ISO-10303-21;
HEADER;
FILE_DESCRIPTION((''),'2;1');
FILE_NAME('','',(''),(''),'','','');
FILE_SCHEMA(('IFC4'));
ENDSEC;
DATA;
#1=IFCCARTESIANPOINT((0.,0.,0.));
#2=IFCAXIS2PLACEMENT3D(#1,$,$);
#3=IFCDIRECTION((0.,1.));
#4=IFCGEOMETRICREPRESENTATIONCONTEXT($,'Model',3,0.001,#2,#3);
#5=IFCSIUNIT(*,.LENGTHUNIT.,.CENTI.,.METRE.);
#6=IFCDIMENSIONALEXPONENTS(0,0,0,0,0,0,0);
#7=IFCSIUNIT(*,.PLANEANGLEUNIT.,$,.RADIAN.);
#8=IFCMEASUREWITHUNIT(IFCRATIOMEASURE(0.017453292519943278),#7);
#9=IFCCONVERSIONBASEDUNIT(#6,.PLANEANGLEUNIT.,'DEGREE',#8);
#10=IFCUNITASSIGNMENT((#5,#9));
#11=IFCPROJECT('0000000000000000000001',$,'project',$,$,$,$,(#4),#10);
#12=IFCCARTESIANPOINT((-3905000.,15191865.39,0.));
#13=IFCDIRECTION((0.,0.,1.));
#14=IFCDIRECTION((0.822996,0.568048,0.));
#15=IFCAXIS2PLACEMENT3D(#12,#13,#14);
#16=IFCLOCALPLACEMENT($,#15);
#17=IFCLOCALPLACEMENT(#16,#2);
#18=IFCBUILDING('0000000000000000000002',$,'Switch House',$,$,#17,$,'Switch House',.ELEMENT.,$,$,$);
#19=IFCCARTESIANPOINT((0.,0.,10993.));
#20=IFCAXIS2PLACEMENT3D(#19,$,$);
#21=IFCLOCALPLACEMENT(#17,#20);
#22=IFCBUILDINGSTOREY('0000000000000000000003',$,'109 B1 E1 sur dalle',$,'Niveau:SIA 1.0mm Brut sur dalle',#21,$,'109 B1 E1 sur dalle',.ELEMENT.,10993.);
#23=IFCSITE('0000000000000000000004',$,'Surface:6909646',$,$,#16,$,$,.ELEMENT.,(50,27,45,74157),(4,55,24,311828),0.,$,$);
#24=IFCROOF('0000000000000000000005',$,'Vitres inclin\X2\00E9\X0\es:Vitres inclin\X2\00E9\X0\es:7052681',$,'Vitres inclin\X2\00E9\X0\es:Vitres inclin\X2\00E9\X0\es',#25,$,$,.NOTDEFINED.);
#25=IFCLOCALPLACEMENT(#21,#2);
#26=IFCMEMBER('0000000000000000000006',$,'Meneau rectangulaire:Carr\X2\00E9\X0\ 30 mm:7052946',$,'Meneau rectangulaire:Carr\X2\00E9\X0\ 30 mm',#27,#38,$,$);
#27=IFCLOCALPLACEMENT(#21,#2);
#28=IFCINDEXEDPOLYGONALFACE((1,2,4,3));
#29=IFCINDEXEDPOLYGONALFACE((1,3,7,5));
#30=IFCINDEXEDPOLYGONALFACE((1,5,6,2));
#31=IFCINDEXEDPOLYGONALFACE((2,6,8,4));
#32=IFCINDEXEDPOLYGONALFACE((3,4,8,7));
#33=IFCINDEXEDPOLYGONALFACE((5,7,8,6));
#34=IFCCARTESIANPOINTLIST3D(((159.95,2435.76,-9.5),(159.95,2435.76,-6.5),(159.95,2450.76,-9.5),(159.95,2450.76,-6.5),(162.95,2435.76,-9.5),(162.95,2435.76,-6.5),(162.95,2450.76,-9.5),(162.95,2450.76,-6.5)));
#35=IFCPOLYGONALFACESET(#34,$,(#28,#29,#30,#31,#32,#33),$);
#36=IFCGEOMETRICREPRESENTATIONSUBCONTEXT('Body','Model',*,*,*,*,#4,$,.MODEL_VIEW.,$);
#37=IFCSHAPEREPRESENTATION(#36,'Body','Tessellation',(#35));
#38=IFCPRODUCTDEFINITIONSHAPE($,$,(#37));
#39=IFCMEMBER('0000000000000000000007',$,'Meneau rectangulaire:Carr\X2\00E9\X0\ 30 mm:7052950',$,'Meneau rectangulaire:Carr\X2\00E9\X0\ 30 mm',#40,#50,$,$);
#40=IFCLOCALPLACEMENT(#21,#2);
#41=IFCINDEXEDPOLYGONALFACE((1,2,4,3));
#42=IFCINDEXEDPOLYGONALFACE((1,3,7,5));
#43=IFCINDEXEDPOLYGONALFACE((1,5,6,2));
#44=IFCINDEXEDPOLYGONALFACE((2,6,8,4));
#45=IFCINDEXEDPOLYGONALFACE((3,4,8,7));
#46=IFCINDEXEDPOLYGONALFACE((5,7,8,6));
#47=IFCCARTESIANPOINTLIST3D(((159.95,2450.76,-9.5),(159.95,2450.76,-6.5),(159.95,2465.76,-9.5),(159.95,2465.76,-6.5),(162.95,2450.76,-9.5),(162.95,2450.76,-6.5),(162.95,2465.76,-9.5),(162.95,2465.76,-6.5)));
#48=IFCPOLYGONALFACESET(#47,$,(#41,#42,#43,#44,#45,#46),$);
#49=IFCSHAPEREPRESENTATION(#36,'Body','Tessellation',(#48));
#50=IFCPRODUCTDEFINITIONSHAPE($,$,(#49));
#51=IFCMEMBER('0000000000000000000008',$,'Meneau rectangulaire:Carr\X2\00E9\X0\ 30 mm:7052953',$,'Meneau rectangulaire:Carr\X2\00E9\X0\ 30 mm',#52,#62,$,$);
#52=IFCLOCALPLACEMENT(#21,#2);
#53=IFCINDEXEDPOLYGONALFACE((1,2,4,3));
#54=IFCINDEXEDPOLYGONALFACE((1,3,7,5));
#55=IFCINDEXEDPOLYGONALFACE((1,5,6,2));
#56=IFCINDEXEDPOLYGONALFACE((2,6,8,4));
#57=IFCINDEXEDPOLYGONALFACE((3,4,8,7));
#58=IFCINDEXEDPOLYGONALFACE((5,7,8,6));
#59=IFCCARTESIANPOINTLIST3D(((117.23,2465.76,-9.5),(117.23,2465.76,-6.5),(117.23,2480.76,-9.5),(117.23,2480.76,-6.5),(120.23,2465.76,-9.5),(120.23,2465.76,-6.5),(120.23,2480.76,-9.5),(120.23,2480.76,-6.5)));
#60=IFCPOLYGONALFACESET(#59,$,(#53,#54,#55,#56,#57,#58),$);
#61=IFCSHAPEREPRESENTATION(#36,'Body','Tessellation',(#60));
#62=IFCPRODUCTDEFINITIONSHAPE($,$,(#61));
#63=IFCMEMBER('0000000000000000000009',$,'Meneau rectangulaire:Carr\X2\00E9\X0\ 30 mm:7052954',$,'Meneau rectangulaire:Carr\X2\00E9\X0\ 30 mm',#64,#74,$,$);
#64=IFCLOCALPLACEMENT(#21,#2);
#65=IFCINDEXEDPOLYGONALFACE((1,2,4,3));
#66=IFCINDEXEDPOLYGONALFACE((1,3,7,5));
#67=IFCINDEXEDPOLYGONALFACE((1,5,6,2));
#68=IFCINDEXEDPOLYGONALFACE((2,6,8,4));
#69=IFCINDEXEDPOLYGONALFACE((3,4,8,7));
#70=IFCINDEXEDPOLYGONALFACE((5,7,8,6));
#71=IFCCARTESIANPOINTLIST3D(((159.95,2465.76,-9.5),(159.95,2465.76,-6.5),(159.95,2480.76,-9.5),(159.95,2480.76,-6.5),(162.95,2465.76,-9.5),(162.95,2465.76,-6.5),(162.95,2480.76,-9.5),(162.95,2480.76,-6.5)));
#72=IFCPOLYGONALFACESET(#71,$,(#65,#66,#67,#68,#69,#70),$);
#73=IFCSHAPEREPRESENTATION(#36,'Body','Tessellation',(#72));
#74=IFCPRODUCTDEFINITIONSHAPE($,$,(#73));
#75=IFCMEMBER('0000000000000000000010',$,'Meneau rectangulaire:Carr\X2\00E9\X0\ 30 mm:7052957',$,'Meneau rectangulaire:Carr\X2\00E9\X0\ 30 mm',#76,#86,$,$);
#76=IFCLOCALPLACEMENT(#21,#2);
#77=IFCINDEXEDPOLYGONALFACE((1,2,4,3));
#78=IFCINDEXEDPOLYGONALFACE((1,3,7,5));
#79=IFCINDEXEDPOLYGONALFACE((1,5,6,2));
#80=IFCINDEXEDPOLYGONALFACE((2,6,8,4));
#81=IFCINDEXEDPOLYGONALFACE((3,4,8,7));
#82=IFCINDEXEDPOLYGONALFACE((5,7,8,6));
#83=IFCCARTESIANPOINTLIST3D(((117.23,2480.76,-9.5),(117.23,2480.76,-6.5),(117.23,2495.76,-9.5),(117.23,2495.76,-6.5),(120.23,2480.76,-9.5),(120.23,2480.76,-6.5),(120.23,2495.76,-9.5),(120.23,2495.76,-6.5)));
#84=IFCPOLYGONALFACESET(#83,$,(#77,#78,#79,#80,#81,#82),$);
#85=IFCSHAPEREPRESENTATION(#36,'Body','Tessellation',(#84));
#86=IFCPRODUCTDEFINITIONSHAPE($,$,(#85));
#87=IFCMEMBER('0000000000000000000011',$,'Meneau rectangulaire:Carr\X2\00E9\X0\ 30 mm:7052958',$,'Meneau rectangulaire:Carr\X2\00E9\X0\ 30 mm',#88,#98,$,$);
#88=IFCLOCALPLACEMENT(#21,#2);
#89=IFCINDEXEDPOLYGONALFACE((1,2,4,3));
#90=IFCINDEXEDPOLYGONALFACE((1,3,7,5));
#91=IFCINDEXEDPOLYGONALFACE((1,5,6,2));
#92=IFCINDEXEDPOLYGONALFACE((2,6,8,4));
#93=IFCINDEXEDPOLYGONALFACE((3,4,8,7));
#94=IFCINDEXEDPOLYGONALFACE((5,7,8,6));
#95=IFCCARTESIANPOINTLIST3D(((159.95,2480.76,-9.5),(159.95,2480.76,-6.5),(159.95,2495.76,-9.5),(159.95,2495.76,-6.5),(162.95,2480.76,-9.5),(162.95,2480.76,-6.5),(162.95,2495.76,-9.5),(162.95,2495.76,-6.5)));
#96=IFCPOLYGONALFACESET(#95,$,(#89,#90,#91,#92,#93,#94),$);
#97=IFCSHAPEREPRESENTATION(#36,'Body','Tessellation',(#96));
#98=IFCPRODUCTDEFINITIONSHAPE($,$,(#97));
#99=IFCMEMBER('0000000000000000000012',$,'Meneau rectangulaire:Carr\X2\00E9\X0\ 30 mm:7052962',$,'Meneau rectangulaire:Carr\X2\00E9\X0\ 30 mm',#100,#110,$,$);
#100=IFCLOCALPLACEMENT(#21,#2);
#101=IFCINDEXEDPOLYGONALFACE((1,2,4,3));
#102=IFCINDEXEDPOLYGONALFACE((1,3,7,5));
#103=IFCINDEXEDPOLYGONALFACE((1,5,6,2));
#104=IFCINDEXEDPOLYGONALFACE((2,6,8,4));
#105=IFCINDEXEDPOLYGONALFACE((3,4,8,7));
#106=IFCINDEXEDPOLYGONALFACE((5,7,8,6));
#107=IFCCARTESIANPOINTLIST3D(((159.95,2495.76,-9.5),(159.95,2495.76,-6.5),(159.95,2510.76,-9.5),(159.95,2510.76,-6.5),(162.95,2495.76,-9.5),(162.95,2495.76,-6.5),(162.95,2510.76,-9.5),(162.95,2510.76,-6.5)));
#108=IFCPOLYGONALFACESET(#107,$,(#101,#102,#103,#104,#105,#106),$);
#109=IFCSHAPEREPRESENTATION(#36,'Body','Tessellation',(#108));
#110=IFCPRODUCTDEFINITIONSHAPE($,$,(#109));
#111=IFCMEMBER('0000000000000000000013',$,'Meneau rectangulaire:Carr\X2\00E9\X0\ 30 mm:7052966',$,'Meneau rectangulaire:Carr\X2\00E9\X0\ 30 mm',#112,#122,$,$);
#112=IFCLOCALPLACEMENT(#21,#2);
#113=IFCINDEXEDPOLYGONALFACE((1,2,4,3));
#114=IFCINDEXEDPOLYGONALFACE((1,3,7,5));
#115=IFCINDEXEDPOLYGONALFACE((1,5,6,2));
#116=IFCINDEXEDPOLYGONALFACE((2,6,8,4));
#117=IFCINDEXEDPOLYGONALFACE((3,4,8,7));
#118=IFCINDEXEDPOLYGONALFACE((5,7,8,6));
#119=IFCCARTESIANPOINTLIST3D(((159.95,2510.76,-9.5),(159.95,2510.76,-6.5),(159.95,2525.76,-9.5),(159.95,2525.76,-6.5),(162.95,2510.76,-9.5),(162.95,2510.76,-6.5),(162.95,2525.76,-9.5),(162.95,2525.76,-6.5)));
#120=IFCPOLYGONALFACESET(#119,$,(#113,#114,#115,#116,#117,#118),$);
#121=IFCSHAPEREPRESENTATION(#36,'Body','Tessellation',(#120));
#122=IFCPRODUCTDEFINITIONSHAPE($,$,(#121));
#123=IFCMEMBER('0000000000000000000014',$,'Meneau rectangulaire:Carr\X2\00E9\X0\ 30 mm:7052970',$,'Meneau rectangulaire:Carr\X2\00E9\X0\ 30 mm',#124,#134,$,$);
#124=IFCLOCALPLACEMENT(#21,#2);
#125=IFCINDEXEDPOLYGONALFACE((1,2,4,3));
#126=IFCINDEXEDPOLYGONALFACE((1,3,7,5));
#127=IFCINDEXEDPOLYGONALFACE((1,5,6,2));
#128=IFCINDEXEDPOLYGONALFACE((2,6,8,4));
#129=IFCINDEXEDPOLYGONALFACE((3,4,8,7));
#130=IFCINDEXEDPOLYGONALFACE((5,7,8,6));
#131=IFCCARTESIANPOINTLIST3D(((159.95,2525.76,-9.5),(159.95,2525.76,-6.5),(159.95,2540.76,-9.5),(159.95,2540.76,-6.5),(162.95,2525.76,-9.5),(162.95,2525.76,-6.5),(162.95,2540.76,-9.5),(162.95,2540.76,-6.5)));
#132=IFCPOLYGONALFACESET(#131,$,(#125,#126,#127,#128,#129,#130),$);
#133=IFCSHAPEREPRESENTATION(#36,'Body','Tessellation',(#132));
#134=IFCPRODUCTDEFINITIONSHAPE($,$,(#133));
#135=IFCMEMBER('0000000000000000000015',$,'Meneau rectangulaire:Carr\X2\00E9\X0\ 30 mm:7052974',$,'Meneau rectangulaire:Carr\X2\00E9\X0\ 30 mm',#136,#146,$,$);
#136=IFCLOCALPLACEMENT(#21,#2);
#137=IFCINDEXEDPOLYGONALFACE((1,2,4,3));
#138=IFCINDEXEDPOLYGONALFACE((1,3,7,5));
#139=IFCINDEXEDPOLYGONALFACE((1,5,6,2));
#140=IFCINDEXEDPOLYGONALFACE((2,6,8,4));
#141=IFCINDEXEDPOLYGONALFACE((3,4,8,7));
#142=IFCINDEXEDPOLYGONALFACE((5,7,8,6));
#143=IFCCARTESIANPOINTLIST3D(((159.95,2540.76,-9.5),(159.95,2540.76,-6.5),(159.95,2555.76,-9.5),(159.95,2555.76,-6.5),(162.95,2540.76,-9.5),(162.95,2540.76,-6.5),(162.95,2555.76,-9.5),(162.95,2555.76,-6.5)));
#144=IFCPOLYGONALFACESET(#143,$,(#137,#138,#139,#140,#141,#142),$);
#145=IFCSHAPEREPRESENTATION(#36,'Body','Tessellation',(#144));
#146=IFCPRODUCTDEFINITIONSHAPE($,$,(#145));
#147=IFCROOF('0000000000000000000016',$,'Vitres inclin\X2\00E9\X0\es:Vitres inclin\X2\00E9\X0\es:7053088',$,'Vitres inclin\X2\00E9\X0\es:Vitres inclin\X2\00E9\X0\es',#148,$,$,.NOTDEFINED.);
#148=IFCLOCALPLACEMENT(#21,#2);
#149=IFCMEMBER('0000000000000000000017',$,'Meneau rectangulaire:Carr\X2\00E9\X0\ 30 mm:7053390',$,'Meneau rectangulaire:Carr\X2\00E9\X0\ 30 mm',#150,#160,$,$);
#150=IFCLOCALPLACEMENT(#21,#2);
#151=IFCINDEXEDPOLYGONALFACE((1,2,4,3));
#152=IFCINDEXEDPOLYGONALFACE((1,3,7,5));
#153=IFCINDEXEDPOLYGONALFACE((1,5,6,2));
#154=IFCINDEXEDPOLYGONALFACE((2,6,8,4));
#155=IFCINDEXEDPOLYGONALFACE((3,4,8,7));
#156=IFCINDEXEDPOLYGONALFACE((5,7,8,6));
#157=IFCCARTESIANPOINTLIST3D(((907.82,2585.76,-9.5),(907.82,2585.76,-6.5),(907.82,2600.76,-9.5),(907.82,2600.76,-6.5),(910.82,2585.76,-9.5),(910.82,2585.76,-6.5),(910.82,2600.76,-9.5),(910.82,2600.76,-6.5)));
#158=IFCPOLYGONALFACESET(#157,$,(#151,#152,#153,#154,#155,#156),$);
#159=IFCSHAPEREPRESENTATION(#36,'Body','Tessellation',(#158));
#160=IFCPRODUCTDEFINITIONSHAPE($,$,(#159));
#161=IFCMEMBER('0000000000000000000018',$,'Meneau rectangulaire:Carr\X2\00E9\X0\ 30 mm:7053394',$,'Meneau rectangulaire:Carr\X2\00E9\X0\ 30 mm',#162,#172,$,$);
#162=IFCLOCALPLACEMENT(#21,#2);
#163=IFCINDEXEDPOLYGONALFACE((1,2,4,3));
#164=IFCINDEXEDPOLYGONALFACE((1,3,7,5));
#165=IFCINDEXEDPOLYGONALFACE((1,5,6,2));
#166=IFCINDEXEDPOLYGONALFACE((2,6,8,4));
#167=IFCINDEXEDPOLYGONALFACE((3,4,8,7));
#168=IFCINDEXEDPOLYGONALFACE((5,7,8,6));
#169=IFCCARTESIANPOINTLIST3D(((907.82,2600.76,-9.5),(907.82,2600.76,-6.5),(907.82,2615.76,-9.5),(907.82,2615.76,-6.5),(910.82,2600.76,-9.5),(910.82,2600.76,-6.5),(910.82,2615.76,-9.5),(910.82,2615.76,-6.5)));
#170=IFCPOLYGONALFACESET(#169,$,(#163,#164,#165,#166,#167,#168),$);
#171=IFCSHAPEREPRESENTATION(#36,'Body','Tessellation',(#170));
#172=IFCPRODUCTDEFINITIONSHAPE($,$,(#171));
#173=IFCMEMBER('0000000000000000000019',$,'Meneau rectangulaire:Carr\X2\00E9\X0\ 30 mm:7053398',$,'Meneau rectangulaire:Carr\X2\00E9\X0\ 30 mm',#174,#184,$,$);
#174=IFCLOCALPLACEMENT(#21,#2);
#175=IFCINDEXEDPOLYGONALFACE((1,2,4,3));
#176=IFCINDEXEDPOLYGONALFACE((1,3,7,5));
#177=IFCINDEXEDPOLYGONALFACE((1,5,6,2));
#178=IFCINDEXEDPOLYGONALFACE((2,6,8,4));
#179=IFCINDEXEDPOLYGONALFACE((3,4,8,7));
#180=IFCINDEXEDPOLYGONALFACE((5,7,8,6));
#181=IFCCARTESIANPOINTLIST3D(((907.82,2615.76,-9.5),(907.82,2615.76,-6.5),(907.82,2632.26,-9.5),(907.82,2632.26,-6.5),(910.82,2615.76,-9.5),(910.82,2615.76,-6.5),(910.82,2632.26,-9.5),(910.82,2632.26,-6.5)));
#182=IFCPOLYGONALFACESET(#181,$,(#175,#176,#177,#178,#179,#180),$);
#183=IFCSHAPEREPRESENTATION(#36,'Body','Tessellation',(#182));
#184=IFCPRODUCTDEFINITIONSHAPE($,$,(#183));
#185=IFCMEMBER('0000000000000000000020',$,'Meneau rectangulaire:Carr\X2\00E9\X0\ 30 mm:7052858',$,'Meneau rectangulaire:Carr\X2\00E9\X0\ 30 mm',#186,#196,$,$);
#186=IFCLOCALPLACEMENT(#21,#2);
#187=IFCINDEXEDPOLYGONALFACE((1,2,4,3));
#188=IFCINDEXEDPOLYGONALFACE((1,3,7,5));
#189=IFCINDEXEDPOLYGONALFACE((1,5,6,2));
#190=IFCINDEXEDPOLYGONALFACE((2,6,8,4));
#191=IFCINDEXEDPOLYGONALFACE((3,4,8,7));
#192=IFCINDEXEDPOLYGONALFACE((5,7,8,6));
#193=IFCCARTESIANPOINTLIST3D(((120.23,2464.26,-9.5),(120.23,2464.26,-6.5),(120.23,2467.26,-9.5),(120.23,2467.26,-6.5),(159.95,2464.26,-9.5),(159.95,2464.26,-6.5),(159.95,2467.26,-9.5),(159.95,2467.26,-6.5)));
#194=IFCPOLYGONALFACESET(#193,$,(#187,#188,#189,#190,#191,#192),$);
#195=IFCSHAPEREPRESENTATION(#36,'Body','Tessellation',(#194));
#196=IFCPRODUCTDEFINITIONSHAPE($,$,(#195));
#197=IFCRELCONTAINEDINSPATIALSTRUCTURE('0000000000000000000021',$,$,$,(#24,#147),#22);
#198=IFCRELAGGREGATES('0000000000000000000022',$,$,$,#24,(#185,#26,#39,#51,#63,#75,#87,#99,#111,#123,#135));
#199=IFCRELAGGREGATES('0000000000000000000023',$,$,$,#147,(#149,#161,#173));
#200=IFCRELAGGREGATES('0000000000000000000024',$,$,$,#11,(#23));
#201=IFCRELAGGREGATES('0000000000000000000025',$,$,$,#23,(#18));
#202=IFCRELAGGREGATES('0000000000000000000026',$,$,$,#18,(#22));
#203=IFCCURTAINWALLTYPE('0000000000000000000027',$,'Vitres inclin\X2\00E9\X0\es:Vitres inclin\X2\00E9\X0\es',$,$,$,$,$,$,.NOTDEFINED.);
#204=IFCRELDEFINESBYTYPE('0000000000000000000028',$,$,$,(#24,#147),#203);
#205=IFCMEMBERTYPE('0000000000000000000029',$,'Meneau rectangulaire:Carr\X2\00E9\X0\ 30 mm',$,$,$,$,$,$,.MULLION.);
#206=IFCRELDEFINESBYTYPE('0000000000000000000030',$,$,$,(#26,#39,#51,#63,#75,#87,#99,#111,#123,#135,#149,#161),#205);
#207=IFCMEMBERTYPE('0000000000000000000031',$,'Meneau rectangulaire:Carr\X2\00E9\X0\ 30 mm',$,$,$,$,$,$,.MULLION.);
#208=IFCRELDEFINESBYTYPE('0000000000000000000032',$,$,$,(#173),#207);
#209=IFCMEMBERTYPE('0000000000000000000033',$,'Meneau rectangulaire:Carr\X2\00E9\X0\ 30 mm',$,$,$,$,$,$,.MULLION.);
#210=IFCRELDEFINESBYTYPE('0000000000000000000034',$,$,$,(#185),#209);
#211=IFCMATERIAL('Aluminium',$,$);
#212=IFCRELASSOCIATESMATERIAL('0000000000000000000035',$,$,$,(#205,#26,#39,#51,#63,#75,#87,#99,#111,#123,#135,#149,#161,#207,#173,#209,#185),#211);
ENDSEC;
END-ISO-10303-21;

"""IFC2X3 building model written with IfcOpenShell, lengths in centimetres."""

from ifc_helpers import new_model, entity, si_unit, converted_unit, direction, frame, origin, origin_2d_with_axis, place, context, subcontext, project, spatial, rectangle, extrude, source, transform, mapped, material, type_object, type_shapes, element, aggregate, save


model = new_model("IFC2X3")

# Units and contexts
model_context = context("Model", 3, precision=0.001, world=origin(), true_north=direction((0.0, 1.0)))
body_context = subcontext(model_context, "Body", "Model", "MODEL_VIEW")
ifc_project = project(units=[si_unit("LENGTHUNIT", "METRE", prefix="CENTI"), converted_unit("PLANEANGLEUNIT", "DEGREE", entity("IfcRatioMeasure", 0.017453292519943278), si_unit("PLANEANGLEUNIT", "RADIAN"), dimensions=[0, 0, 0, 0, 0, 0, 0])], contexts=[model_context])

# Site, building, storey
site_placement = place(None, frame((-3905000.0, 15191865.39, 0.0), z_axis=(0.0, 0.0, 1.0), x_axis=(0.822996, 0.568048, 0.0)))
site = spatial("IfcSite", under=ifc_project, at=site_placement, Name="Surface:6909646", CompositionType="ELEMENT", RefLatitude=(50, 27, 45, 74157), RefLongitude=(4, 55, 24, 311828), RefElevation=0.0)
building_placement = place(site_placement, origin())
building = spatial("IfcBuilding", under=site, at=building_placement, Name="Switch House", LongName="Switch House", CompositionType="ELEMENT")
storey_placement = place(building_placement, frame((0.0, 0.0, 10993.0)))
storey = spatial("IfcBuildingStorey", under=building, at=storey_placement, Name="109 B1 E1 sur dalle", ObjectType="Niveau:SIA 1.0mm Brut sur dalle", LongName="109 B1 E1 sur dalle", CompositionType="ELEMENT", Elevation=10993.0)

# Roofs, members
curtain_wall_type = type_object("IfcCurtainWallType", Name="Vitres inclinées:Vitres inclinées", PredefinedType="NOTDEFINED")
roof_1_placement = place(storey_placement, frame((0.0, 0.0, -10993.0)))
roof_1 = element("IfcRoof", 1, at=roof_1_placement, inside=storey, type_object=curtain_wall_type, Name="Vitres inclinées:Vitres inclinées:7052681", ObjectType="Vitres inclinées:Vitres inclinées", ShapeType="NOTDEFINED")
ifc_material = material(Name="Aluminium")
member_type_1 = type_object("IfcMemberType", Name="Meneau rectangulaire:Carré 30 mm", PredefinedType="MULLION", material=ifc_material)
shared_shape_1 = source(origin(), body_context, "Body", "SweptSolid", [
    extrude(rectangle(XDim=3.0, YDim=3.0, at=origin_2d_with_axis()), frame((0.0, 0.0, -15.0), z_axis=(0.0, 0.0, 1.0), x_axis=(0.0, -1.0, 0.0)), (0.0, 0.0, 1.0), 15.0),
])
type_shapes(member_type_1, [shared_shape_1])
member_1_placement = place(roof_1_placement, frame((161.45, 2450.76, 10985.0), z_axis=(0.0, 1.0, 0.0), x_axis=(1.0, 0.0, 0.0)))
member_1 = element("IfcMember", 2, at=member_1_placement, type_object=member_type_1, material=ifc_material, Name="Meneau rectangulaire:Carré 30 mm:7052946", ObjectType="Meneau rectangulaire:Carré 30 mm", context=body_context, shape_type="MappedRepresentation", body=[
    mapped(shared_shape_1, transform((0.0, 0.0, 0.0), scale=1.0)),
])
member_2_placement = place(roof_1_placement, frame((161.45, 2465.76, 10985.0), z_axis=(0.0, 1.0, 0.0), x_axis=(1.0, 0.0, 0.0)))
member_2 = element("IfcMember", 3, at=member_2_placement, type_object=member_type_1, material=ifc_material, Name="Meneau rectangulaire:Carré 30 mm:7052950", ObjectType="Meneau rectangulaire:Carré 30 mm", context=body_context, shape_type="MappedRepresentation", body=[
    mapped(shared_shape_1, transform((0.0, 0.0, 0.0), scale=1.0)),
])
member_3_placement = place(roof_1_placement, frame((118.73, 2480.76, 10985.0), z_axis=(0.0, 1.0, 0.0), x_axis=(1.0, 0.0, 0.0)))
member_3 = element("IfcMember", 4, at=member_3_placement, type_object=member_type_1, material=ifc_material, Name="Meneau rectangulaire:Carré 30 mm:7052953", ObjectType="Meneau rectangulaire:Carré 30 mm", context=body_context, shape_type="MappedRepresentation", body=[
    mapped(shared_shape_1, transform((0.0, 0.0, 0.0), scale=1.0)),
])
member_4_placement = place(roof_1_placement, frame((161.45, 2480.76, 10985.0), z_axis=(0.0, 1.0, 0.0), x_axis=(1.0, 0.0, 0.0)))
member_4 = element("IfcMember", 5, at=member_4_placement, type_object=member_type_1, material=ifc_material, Name="Meneau rectangulaire:Carré 30 mm:7052954", ObjectType="Meneau rectangulaire:Carré 30 mm", context=body_context, shape_type="MappedRepresentation", body=[
    mapped(shared_shape_1, transform((0.0, 0.0, 0.0), scale=1.0)),
])
member_5_placement = place(roof_1_placement, frame((118.73, 2495.76, 10985.0), z_axis=(0.0, 1.0, 0.0), x_axis=(1.0, 0.0, 0.0)))
member_5 = element("IfcMember", 6, at=member_5_placement, type_object=member_type_1, material=ifc_material, Name="Meneau rectangulaire:Carré 30 mm:7052957", ObjectType="Meneau rectangulaire:Carré 30 mm", context=body_context, shape_type="MappedRepresentation", body=[
    mapped(shared_shape_1, transform((0.0, 0.0, 0.0), scale=1.0)),
])
member_6_placement = place(roof_1_placement, frame((161.45, 2495.76, 10985.0), z_axis=(0.0, 1.0, 0.0), x_axis=(1.0, 0.0, 0.0)))
member_6 = element("IfcMember", 7, at=member_6_placement, type_object=member_type_1, material=ifc_material, Name="Meneau rectangulaire:Carré 30 mm:7052958", ObjectType="Meneau rectangulaire:Carré 30 mm", context=body_context, shape_type="MappedRepresentation", body=[
    mapped(shared_shape_1, transform((0.0, 0.0, 0.0), scale=1.0)),
])
member_7_placement = place(roof_1_placement, frame((161.45, 2510.76, 10985.0), z_axis=(0.0, 1.0, 0.0), x_axis=(1.0, 0.0, 0.0)))
member_7 = element("IfcMember", 8, at=member_7_placement, type_object=member_type_1, material=ifc_material, Name="Meneau rectangulaire:Carré 30 mm:7052962", ObjectType="Meneau rectangulaire:Carré 30 mm", context=body_context, shape_type="MappedRepresentation", body=[
    mapped(shared_shape_1, transform((0.0, 0.0, 0.0), scale=1.0)),
])
member_8_placement = place(roof_1_placement, frame((161.45, 2525.76, 10985.0), z_axis=(0.0, 1.0, 0.0), x_axis=(1.0, 0.0, 0.0)))
member_8 = element("IfcMember", 9, at=member_8_placement, type_object=member_type_1, material=ifc_material, Name="Meneau rectangulaire:Carré 30 mm:7052966", ObjectType="Meneau rectangulaire:Carré 30 mm", context=body_context, shape_type="MappedRepresentation", body=[
    mapped(shared_shape_1, transform((0.0, 0.0, 0.0), scale=1.0)),
])
member_9_placement = place(roof_1_placement, frame((161.45, 2540.76, 10985.0), z_axis=(0.0, 1.0, 0.0), x_axis=(1.0, 0.0, 0.0)))
member_9 = element("IfcMember", 10, at=member_9_placement, type_object=member_type_1, material=ifc_material, Name="Meneau rectangulaire:Carré 30 mm:7052970", ObjectType="Meneau rectangulaire:Carré 30 mm", context=body_context, shape_type="MappedRepresentation", body=[
    mapped(shared_shape_1, transform((0.0, 0.0, 0.0), scale=1.0)),
])
member_10_placement = place(roof_1_placement, frame((161.45, 2555.76, 10985.0), z_axis=(0.0, 1.0, 0.0), x_axis=(1.0, 0.0, 0.0)))
member_10 = element("IfcMember", 11, at=member_10_placement, type_object=member_type_1, material=ifc_material, Name="Meneau rectangulaire:Carré 30 mm:7052974", ObjectType="Meneau rectangulaire:Carré 30 mm", context=body_context, shape_type="MappedRepresentation", body=[
    mapped(shared_shape_1, transform((0.0, 0.0, 0.0), scale=1.0)),
])
roof_2_placement = place(storey_placement, frame((0.0, 0.0, -10993.0)))
roof_2 = element("IfcRoof", 12, at=roof_2_placement, inside=storey, type_object=curtain_wall_type, Name="Vitres inclinées:Vitres inclinées:7053088", ObjectType="Vitres inclinées:Vitres inclinées", ShapeType="NOTDEFINED")
member_11_placement = place(roof_2_placement, frame((909.32, 2600.76, 10985.0), z_axis=(0.0, 1.0, 0.0), x_axis=(1.0, 0.0, 0.0)))
member_11 = element("IfcMember", 13, at=member_11_placement, type_object=member_type_1, material=ifc_material, Name="Meneau rectangulaire:Carré 30 mm:7053390", ObjectType="Meneau rectangulaire:Carré 30 mm", context=body_context, shape_type="MappedRepresentation", body=[
    mapped(shared_shape_1, transform((0.0, 0.0, 0.0), scale=1.0)),
])
member_12_placement = place(roof_2_placement, frame((909.32, 2615.76, 10985.0), z_axis=(0.0, 1.0, 0.0), x_axis=(1.0, 0.0, 0.0)))
member_12 = element("IfcMember", 14, at=member_12_placement, type_object=member_type_1, material=ifc_material, Name="Meneau rectangulaire:Carré 30 mm:7053394", ObjectType="Meneau rectangulaire:Carré 30 mm", context=body_context, shape_type="MappedRepresentation", body=[
    mapped(shared_shape_1, transform((0.0, 0.0, 0.0), scale=1.0)),
])
member_type_2 = type_object("IfcMemberType", Name="Meneau rectangulaire:Carré 30 mm", PredefinedType="MULLION", material=ifc_material)
shared_shape_2 = source(origin(), body_context, "Body", "SweptSolid", [
    extrude(rectangle(XDim=3.0, YDim=3.0, at=origin_2d_with_axis()), frame((0.0, 0.0, -16.5), z_axis=(0.0, 0.0, 1.0), x_axis=(0.0, -1.0, 0.0)), (0.0, 0.0, 1.0), 16.5),
])
type_shapes(member_type_2, [shared_shape_2])
member_13_placement = place(roof_2_placement, frame((909.32, 2632.26, 10985.0), z_axis=(0.0, 1.0, 0.0), x_axis=(1.0, 0.0, 0.0)))
member_13 = element("IfcMember", 15, at=member_13_placement, type_object=member_type_2, material=ifc_material, Name="Meneau rectangulaire:Carré 30 mm:7053398", ObjectType="Meneau rectangulaire:Carré 30 mm", context=body_context, shape_type="MappedRepresentation", body=[
    mapped(shared_shape_2, transform((0.0, 0.0, 0.0), scale=1.0)),
])

# Member
member_type_3 = type_object("IfcMemberType", Name="Meneau rectangulaire:Carré 30 mm", PredefinedType="MULLION", material=ifc_material)
shared_shape_3 = source(origin(), body_context, "Body", "SweptSolid", [
    extrude(rectangle(XDim=3.0, YDim=3.0, at=origin_2d_with_axis()), frame((0.0, 0.0, -39.72), z_axis=(0.0, 0.0, 1.0), x_axis=(0.0, -1.0, 0.0)), (0.0, 0.0, 1.0), 39.72),
])
type_shapes(member_type_3, [shared_shape_3])
member_14_placement = place(roof_1_placement, frame((120.23, 2465.76, 10985.0), z_axis=(-1.0, 0.0, 0.0), x_axis=(0.0, 1.0, 0.0)))
member_14 = element("IfcMember", 16, at=member_14_placement, type_object=member_type_3, material=ifc_material, Name="Meneau rectangulaire:Carré 30 mm:7052858", ObjectType="Meneau rectangulaire:Carré 30 mm", context=body_context, shape_type="MappedRepresentation", body=[
    mapped(shared_shape_3, transform((0.0, 0.0, 0.0), scale=1.0)),
])
aggregate(roof_1, [member_14, member_1, member_2, member_3, member_4, member_5, member_6, member_7, member_8, member_9, member_10])
aggregate(roof_2, [member_11, member_12, member_13])

save(model, "model.ifc")
